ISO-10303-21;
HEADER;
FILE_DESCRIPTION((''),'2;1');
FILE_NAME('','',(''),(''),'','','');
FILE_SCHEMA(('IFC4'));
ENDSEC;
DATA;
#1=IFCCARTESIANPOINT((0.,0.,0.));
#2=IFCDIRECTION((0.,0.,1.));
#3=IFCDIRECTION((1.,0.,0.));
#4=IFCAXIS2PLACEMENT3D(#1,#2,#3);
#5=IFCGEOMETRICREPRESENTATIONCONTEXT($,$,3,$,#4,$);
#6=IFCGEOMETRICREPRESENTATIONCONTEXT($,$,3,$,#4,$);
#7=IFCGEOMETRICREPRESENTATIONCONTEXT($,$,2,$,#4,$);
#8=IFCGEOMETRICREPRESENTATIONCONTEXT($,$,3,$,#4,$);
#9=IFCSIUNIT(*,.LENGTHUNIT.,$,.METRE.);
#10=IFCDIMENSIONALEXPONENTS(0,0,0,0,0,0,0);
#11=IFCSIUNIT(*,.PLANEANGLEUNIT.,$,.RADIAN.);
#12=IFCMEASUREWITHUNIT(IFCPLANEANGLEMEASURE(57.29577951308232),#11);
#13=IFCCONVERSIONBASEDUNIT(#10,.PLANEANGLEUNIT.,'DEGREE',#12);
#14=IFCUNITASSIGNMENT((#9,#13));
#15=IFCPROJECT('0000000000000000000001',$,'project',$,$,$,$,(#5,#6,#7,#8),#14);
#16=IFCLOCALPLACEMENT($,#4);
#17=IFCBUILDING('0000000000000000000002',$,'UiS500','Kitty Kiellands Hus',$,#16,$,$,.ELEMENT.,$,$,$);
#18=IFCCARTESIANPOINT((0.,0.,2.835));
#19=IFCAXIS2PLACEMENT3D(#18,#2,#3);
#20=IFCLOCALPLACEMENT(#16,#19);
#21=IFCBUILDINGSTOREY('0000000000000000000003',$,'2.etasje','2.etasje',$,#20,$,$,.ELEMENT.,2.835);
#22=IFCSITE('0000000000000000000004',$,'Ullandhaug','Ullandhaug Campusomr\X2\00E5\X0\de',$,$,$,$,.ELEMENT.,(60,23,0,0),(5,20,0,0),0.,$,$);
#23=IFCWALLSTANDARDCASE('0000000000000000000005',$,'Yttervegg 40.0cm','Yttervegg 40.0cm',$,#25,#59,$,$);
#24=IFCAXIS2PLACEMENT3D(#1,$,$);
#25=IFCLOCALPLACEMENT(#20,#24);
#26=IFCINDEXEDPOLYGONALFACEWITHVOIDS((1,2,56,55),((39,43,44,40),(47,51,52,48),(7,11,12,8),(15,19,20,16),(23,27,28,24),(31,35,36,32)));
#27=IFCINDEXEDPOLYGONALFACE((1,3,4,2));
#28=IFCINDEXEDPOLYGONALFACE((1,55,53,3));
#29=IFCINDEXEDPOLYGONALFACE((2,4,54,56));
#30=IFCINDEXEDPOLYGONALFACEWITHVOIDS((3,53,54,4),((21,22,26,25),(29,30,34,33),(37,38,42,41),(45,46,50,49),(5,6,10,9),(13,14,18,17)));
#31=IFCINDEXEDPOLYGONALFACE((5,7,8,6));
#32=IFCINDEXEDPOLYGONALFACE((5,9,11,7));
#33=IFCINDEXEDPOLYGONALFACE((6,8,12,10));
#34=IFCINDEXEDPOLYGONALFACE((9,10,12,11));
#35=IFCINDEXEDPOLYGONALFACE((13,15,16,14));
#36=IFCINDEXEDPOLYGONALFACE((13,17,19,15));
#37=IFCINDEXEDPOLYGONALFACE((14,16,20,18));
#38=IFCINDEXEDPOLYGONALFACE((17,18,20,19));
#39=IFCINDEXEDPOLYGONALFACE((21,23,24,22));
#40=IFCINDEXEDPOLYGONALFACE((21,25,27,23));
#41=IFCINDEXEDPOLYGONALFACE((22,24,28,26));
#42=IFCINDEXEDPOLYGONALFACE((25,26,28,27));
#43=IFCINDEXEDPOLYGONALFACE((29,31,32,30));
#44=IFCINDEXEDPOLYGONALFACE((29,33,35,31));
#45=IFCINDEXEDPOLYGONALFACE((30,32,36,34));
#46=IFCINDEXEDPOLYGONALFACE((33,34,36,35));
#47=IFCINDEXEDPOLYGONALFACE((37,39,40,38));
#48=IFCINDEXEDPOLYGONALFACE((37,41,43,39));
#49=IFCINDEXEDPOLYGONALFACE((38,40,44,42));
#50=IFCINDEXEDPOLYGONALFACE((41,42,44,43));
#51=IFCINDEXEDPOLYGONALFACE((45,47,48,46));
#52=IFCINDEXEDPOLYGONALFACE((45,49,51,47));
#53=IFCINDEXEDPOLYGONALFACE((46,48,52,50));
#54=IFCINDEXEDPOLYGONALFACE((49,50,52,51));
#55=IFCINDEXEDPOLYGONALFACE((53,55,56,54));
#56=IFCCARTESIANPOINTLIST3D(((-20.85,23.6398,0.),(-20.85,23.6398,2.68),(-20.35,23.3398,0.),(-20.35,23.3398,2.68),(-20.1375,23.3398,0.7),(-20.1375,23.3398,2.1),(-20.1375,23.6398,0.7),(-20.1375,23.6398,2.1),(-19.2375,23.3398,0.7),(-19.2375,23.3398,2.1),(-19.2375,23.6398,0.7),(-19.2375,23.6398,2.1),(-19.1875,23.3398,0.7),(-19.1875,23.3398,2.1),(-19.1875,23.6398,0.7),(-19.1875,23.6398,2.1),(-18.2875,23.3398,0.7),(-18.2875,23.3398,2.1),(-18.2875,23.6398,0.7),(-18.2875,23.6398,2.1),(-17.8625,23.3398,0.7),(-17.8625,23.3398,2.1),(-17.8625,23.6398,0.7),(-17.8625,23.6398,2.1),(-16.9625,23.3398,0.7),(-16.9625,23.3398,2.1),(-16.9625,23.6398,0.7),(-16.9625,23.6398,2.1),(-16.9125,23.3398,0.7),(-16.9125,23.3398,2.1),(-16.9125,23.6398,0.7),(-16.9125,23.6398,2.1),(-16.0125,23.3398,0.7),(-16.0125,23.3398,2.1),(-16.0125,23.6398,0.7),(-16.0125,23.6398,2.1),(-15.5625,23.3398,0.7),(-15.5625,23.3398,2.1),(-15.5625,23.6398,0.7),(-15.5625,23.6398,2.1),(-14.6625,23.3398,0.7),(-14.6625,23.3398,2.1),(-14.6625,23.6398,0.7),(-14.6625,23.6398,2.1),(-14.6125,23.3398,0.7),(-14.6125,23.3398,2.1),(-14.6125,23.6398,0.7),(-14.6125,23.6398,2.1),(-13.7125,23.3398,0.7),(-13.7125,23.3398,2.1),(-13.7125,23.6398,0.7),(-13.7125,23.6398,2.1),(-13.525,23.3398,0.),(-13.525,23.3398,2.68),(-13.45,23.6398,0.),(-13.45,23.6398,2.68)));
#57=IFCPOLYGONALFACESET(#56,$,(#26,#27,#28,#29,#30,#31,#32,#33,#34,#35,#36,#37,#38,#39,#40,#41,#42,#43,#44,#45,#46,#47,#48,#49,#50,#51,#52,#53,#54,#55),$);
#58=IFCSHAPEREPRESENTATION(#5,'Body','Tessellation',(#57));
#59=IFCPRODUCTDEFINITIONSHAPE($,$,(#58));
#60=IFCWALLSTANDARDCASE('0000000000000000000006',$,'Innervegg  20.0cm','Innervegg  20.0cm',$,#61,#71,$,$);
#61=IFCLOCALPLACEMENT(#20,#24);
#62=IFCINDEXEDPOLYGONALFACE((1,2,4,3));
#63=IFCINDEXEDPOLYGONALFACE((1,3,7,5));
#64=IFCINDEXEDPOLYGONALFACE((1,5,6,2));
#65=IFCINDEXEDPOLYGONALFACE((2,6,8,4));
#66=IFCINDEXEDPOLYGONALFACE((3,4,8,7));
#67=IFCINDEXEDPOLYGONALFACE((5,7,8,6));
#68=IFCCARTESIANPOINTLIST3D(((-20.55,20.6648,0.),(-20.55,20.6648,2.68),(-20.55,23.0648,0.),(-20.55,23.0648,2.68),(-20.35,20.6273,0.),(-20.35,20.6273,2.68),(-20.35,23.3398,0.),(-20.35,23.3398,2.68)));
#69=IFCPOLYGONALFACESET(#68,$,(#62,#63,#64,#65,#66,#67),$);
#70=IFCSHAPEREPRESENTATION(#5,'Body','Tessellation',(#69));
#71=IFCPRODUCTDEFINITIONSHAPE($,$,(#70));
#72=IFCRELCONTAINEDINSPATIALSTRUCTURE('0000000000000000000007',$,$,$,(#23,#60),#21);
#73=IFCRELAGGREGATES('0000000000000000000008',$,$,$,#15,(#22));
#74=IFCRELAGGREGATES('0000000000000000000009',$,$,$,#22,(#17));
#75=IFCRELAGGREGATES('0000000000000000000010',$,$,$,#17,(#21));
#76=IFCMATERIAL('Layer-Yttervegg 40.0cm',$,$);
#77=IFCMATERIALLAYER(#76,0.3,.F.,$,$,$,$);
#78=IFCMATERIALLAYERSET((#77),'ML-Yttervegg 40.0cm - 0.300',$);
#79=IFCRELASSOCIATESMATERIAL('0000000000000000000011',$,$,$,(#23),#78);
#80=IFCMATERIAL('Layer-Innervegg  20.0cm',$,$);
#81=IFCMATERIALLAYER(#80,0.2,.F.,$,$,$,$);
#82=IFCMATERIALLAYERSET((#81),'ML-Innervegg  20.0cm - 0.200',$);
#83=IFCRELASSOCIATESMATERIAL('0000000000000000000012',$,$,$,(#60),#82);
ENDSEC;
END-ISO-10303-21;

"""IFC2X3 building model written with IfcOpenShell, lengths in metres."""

from ifc_helpers import new_model, entity, si_unit, converted_unit, frame, origin_with_axes, place, context, project, spatial, polyline, outline, extrude, material, layer, layer_set, layer_usage, element, save


model = new_model("IFC2X3")

# Units and contexts
context_of_model_1 = context(None, 3, world=origin_with_axes())
context_of_model_2 = context(None, 3, world=origin_with_axes())
context_of_model_3 = context(None, 2, world=origin_with_axes())
context_of_model_4 = context(None, 3, world=origin_with_axes())
ifc_project = project(units=[si_unit("LENGTHUNIT", "METRE"), converted_unit("PLANEANGLEUNIT", "DEGREE", entity("IfcPlaneAngleMeasure", 57.29577951308232), si_unit("PLANEANGLEUNIT", "RADIAN"), dimensions=[0, 0, 0, 0, 0, 0, 0])], contexts=[context_of_model_1, context_of_model_2, context_of_model_3, context_of_model_4])

# Site, building, storey
site = spatial("IfcSite", under=ifc_project, Name="Ullandhaug", Description="Ullandhaug Campusområde", CompositionType="ELEMENT", RefLatitude=(60, 23, 0, 0), RefLongitude=(5, 20, 0, 0), RefElevation=0.0)
building_placement = place(None, origin_with_axes())
building = spatial("IfcBuilding", under=site, at=building_placement, Name="UiS500", Description="Kitty Kiellands Hus", CompositionType="ELEMENT")
storey_placement = place(building_placement, frame((0.0, 0.0, 2.835), z_axis=(0.0, 0.0, 1.0), x_axis=(1.0, 0.0, 0.0)))
storey = spatial("IfcBuildingStorey", under=building, at=storey_placement, Name="2.etasje", Description="2.etasje", CompositionType="ELEMENT", Elevation=2.835)

# Shared definitions
ifc_material_1 = material(Name="Layer-Innervegg  20.0cm")
ifc_layer_1 = layer(ifc_material_1, 0.2, ventilated=False)
ifc_layer_set_1 = layer_set([ifc_layer_1], Name="ML-Innervegg  20.0cm - 0.200")
ifc_layer_usage_1 = layer_usage(ifc_layer_set_1, "AXIS2", "POSITIVE", 0.0)

# Wall, openings
ifc_material_2 = material(Name="Layer-Yttervegg 40.0cm")
ifc_layer_2 = layer(ifc_material_2, 0.3, ventilated=False)
ifc_layer_set_2 = layer_set([ifc_layer_2], Name="ML-Yttervegg 40.0cm - 0.300")
ifc_layer_usage_2 = layer_usage(ifc_layer_set_2, "AXIS2", "POSITIVE", 0.0)
wall_1_placement = place(storey_placement, frame((-13.45, 23.6398, 0.0), z_axis=(0.0, 0.0, 1.0), x_axis=(-1.0, 0.0, 0.0)))
wall_1 = element("IfcWallStandardCase", 1, at=wall_1_placement, inside=storey, material=ifc_layer_usage_2, Name="Yttervegg 40.0cm", Description="Yttervegg 40.0cm", context=context_of_model_1, shape_type="SweptSolid", body=[
    extrude(outline(polyline([(0.0, 0.0), (7.4, 0.0), (6.9, 0.3), (0.075, 0.3), (0.0, 0.0)])), frame((0.0, 0.0, 0.0), z_axis=(0.0, 0.0, 1.0), x_axis=(1.0, 0.0, 0.0)), (0.0, 0.0, 1.0), 2.68),
])
opening_1_placement = place(wall_1_placement, frame((0.2625, 0.3, 0.7), z_axis=(0.0, 0.0, 1.0), x_axis=(1.0, 0.0, 0.0)))
element("IfcOpeningElement", 2, at=opening_1_placement, cuts=wall_1, context=context_of_model_1, shape_type="SweptSolid", body=[
    extrude(outline(polyline([(0.0, 0.0), (1.4, 0.0), (1.4, 0.9), (0.0, 0.9), (0.0, 0.0)])), frame((0.0, 0.0, 0.0), z_axis=(0.0, 1.0, 0.0), x_axis=(0.0, 0.0, 1.0)), (0.0, 0.0, -1.0), 0.3),
])
opening_2_placement = place(wall_1_placement, frame((1.2125, 0.3, 0.7), z_axis=(0.0, 0.0, 1.0), x_axis=(1.0, 0.0, 0.0)))
element("IfcOpeningElement", 3, at=opening_2_placement, cuts=wall_1, context=context_of_model_1, shape_type="SweptSolid", body=[
    extrude(outline(polyline([(0.0, 0.0), (1.4, 0.0), (1.4, 0.9), (0.0, 0.9), (0.0, 0.0)])), frame((0.0, 0.0, 0.0), z_axis=(0.0, 1.0, 0.0), x_axis=(0.0, 0.0, 1.0)), (0.0, 0.0, -1.0), 0.3),
])
opening_3_placement = place(wall_1_placement, frame((2.5625, 0.3, 0.7), z_axis=(0.0, 0.0, 1.0), x_axis=(1.0, 0.0, 0.0)))
element("IfcOpeningElement", 4, at=opening_3_placement, cuts=wall_1, context=context_of_model_1, shape_type="SweptSolid", body=[
    extrude(outline(polyline([(0.0, 0.0), (1.4, 0.0), (1.4, 0.9), (0.0, 0.9), (0.0, 0.0)])), frame((0.0, 0.0, 0.0), z_axis=(0.0, 1.0, 0.0), x_axis=(0.0, 0.0, 1.0)), (0.0, 0.0, -1.0), 0.3),
])
opening_4_placement = place(wall_1_placement, frame((3.5125, 0.3, 0.7), z_axis=(0.0, 0.0, 1.0), x_axis=(1.0, 0.0, 0.0)))
element("IfcOpeningElement", 5, at=opening_4_placement, cuts=wall_1, context=context_of_model_1, shape_type="SweptSolid", body=[
    extrude(outline(polyline([(0.0, 0.0), (1.4, 0.0), (1.4, 0.9), (0.0, 0.9), (0.0, 0.0)])), frame((0.0, 0.0, 0.0), z_axis=(0.0, 1.0, 0.0), x_axis=(0.0, 0.0, 1.0)), (0.0, 0.0, -1.0), 0.3),
])
opening_5_placement = place(wall_1_placement, frame((4.8375, 0.3, 0.7), z_axis=(0.0, 0.0, 1.0), x_axis=(1.0, 0.0, 0.0)))
element("IfcOpeningElement", 6, at=opening_5_placement, cuts=wall_1, context=context_of_model_1, shape_type="SweptSolid", body=[
    extrude(outline(polyline([(0.0, 0.0), (1.4, 0.0), (1.4, 0.9), (0.0, 0.9), (0.0, 0.0)])), frame((0.0, 0.0, 0.0), z_axis=(0.0, 1.0, 0.0), x_axis=(0.0, 0.0, 1.0)), (0.0, 0.0, -1.0), 0.3),
])
opening_6_placement = place(wall_1_placement, frame((5.7875, 0.3, 0.7), z_axis=(0.0, 0.0, 1.0), x_axis=(1.0, 0.0, 0.0)))
element("IfcOpeningElement", 7, at=opening_6_placement, cuts=wall_1, context=context_of_model_1, shape_type="SweptSolid", body=[
    extrude(outline(polyline([(0.0, 0.0), (1.4, 0.0), (1.4, 0.9), (0.0, 0.9), (0.0, 0.0)])), frame((0.0, 0.0, 0.0), z_axis=(0.0, 1.0, 0.0), x_axis=(0.0, 0.0, 1.0)), (0.0, 0.0, -1.0), 0.3),
])

# Wall
wall_2_placement = place(storey_placement, frame((-20.55, 23.0648, 0.0), z_axis=(0.0, 0.0, 1.0), x_axis=(0.0, -1.0, 0.0)))
element("IfcWallStandardCase", 8, at=wall_2_placement, inside=storey, material=ifc_layer_usage_1, Name="Innervegg  20.0cm", Description="Innervegg  20.0cm", context=context_of_model_1, shape_type="SweptSolid", body=[
    extrude(outline(polyline([(0.0, 0.0), (2.4, 0.0), (2.4375, 0.2), (-0.275, 0.2), (0.0, 0.0)])), frame((0.0, 0.0, 0.0), z_axis=(0.0, 0.0, 1.0), x_axis=(1.0, 0.0, 0.0)), (0.0, 0.0, 1.0), 2.68),
])

save(model, "model.ifc")
